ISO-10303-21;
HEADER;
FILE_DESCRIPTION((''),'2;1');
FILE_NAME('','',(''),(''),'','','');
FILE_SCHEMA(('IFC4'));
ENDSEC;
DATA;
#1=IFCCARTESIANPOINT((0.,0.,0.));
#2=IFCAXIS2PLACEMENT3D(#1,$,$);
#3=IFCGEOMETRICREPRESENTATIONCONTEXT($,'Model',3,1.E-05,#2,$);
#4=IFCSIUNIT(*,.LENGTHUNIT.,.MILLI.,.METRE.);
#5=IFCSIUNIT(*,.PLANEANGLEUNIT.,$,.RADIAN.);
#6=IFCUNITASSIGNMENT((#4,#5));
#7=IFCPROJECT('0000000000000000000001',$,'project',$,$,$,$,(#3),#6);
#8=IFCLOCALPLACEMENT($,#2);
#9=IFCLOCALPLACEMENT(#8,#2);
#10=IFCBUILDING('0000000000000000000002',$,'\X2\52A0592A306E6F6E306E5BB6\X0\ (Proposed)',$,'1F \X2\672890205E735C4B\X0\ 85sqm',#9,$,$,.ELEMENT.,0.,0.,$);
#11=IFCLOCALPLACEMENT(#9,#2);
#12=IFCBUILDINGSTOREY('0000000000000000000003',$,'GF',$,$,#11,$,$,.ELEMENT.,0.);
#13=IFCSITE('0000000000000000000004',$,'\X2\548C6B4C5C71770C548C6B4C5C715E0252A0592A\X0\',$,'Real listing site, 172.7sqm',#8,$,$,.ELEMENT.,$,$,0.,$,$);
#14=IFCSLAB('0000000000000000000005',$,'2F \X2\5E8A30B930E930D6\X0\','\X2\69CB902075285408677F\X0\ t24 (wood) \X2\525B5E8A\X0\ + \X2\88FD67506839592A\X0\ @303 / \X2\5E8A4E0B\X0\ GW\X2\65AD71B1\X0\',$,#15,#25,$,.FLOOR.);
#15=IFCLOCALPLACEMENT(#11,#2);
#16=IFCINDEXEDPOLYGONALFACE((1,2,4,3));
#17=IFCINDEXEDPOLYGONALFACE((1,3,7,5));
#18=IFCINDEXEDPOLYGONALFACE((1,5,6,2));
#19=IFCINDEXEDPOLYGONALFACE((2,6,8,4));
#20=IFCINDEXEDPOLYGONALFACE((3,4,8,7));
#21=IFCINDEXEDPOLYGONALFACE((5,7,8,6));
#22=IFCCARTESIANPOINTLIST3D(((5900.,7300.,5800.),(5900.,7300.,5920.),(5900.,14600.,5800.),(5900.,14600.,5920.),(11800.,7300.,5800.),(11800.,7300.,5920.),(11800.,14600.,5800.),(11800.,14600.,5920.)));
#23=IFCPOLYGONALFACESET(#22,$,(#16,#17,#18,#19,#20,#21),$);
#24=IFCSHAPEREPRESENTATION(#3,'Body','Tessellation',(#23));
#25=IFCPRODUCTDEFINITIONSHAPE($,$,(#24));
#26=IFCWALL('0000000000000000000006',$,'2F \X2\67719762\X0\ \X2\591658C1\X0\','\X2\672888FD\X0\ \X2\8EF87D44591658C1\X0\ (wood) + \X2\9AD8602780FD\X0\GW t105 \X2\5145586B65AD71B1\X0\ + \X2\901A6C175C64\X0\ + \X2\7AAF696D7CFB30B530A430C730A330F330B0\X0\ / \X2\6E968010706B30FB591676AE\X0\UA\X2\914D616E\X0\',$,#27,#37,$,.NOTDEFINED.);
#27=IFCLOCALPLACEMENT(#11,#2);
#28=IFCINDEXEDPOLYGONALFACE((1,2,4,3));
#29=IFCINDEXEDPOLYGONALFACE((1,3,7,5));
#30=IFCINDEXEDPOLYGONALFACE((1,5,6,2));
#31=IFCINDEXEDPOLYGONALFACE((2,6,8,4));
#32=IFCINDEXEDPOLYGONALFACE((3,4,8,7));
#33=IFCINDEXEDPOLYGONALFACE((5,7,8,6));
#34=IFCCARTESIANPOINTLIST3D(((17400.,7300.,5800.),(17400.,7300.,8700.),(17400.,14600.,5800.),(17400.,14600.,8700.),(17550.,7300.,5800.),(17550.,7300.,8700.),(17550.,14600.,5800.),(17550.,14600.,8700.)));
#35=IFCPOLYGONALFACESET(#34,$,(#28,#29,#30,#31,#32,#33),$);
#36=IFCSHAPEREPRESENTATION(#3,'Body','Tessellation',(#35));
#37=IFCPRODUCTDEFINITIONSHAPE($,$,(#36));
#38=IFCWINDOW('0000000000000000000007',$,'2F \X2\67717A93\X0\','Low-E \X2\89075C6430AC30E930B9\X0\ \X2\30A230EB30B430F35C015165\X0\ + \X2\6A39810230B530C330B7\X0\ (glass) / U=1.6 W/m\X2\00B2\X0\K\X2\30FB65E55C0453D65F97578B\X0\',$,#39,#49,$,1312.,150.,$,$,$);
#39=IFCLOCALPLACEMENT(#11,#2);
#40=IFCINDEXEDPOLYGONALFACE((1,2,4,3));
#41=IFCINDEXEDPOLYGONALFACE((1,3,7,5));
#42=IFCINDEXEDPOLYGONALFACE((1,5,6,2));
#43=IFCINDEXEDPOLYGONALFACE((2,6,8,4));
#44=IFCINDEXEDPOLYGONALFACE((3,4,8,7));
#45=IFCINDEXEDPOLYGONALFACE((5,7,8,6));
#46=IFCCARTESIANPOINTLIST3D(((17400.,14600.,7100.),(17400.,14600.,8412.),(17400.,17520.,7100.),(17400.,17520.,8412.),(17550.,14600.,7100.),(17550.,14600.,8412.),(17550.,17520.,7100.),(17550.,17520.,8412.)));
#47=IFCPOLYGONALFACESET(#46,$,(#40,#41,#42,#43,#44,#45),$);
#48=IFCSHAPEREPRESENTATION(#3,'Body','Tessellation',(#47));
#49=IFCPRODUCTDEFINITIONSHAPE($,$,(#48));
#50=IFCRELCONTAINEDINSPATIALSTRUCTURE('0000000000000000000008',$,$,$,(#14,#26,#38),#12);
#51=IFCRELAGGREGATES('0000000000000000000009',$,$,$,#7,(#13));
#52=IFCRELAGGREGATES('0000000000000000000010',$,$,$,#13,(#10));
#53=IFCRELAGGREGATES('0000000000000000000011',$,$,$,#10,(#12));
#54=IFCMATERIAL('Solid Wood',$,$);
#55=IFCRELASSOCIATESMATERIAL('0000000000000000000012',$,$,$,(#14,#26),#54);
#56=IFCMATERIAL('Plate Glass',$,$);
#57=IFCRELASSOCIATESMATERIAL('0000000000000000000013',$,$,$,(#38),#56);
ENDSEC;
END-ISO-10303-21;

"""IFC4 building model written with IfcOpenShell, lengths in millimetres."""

from ifc_helpers import new_model, si_unit, frame, frame_2d, origin, place, context, project, spatial, rectangle, extrude, material, element, fill, save


model = new_model("IFC4")

# Units and contexts
model_context = context("Model", 3, precision=1e-05, world=origin())
ifc_project = project(units=[si_unit("LENGTHUNIT", "METRE", prefix="MILLI"), si_unit("PLANEANGLEUNIT", "RADIAN")], contexts=[model_context])

# Site, building, storey
site_placement = place(None, origin())
site = spatial("IfcSite", under=ifc_project, at=site_placement, Name="和歌山県和歌山市加太", ObjectType="Real listing site, 172.7sqm", CompositionType="ELEMENT", RefElevation=0.0)
building_placement = place(site_placement, origin())
building = spatial("IfcBuilding", under=site, at=building_placement, Name="加太の潮の家 (Proposed)", ObjectType="1F 木造平屋 85sqm", CompositionType="ELEMENT", ElevationOfRefHeight=0.0, ElevationOfTerrain=0.0)
storey_placement = place(building_placement, origin())
storey = spatial("IfcBuildingStorey", under=building, at=storey_placement, Name="GF", CompositionType="ELEMENT", Elevation=0.0)

# Slab
ifc_material_1 = material(Name="Solid Wood")
slab_placement = place(storey_placement, frame((2950.0, 3650.0, 2900.0)))
element("IfcSlab", 1, at=slab_placement, inside=storey, material=ifc_material_1, Name="2F 床スラブ", Description="構造用合板 t24 (wood) 剛床 + 製材根太 @303 / 床下 GW断熱", PredefinedType="FLOOR", context=model_context, shape_type="SweptSolid", body=[
    extrude(rectangle(XDim=5900.0, YDim=7300.0, at=frame_2d((2950.0, 3650.0))), frame((2950.0, 3650.0, 2900.0)), (0.0, 0.0, 1.0), 120.0),
])

# Shared definitions
ifc_material_2 = material(Name="Plate Glass")

# Wall, opening, window
wall_1_placement = place(storey_placement, frame((8700.0, 3650.0, 2900.0)))
wall_1 = element("IfcWall", 2, at=wall_1_placement, inside=storey, material=ifc_material_1, Name="2F 東面 外壁", Description="木製 軸組外壁 (wood) + 高性能GW t105 充填断熱 + 通気層 + 窯業系サイディング / 準耐火・外皮UA配慮", PredefinedType="NOTDEFINED", context=model_context, shape_type="SweptSolid", body=[
    extrude(rectangle(XDim=150.0, YDim=7300.0, at=frame_2d((75.0, 3650.0))), frame((8700.0, 3650.0, 2900.0)), (0.0, 0.0, 1.0), 2900.0),
])
opening_1_placement = place(storey_placement, frame((8700.0, 7300.0, 3550.0)))
opening_1 = element("IfcOpeningElement", 3, at=opening_1_placement, cuts=wall_1, PredefinedType="NOTDEFINED", context=model_context, shape_type="SweptSolid", body=[
    extrude(rectangle(XDim=150.0, YDim=2920.0, at=frame_2d((75.0, 1460.0))), frame((8700.0, 7300.0, 3550.0)), (0.0, 0.0, 1.0), 1312.0),
])
window_1_placement = place(storey_placement, frame((8700.0, 7300.0, 3550.0)))
window_1 = element("IfcWindow", 4, at=window_1_placement, inside=storey, material=ifc_material_2, Name="2F 東窓", Description="Low-E 複層ガラス アルゴン封入 + 樹脂サッシ (glass) / U=1.6 W/m²K・日射取得型", OverallHeight=1312.0, OverallWidth=150.0, context=model_context, shape_type="SweptSolid", body=[
    extrude(rectangle(XDim=150.0, YDim=2920.0, at=frame_2d((75.0, 1460.0))), frame((8700.0, 7300.0, 3550.0)), (0.0, 0.0, 1.0), 1312.0),
])
fill(opening_1, window_1)

save(model, "model.ifc")
